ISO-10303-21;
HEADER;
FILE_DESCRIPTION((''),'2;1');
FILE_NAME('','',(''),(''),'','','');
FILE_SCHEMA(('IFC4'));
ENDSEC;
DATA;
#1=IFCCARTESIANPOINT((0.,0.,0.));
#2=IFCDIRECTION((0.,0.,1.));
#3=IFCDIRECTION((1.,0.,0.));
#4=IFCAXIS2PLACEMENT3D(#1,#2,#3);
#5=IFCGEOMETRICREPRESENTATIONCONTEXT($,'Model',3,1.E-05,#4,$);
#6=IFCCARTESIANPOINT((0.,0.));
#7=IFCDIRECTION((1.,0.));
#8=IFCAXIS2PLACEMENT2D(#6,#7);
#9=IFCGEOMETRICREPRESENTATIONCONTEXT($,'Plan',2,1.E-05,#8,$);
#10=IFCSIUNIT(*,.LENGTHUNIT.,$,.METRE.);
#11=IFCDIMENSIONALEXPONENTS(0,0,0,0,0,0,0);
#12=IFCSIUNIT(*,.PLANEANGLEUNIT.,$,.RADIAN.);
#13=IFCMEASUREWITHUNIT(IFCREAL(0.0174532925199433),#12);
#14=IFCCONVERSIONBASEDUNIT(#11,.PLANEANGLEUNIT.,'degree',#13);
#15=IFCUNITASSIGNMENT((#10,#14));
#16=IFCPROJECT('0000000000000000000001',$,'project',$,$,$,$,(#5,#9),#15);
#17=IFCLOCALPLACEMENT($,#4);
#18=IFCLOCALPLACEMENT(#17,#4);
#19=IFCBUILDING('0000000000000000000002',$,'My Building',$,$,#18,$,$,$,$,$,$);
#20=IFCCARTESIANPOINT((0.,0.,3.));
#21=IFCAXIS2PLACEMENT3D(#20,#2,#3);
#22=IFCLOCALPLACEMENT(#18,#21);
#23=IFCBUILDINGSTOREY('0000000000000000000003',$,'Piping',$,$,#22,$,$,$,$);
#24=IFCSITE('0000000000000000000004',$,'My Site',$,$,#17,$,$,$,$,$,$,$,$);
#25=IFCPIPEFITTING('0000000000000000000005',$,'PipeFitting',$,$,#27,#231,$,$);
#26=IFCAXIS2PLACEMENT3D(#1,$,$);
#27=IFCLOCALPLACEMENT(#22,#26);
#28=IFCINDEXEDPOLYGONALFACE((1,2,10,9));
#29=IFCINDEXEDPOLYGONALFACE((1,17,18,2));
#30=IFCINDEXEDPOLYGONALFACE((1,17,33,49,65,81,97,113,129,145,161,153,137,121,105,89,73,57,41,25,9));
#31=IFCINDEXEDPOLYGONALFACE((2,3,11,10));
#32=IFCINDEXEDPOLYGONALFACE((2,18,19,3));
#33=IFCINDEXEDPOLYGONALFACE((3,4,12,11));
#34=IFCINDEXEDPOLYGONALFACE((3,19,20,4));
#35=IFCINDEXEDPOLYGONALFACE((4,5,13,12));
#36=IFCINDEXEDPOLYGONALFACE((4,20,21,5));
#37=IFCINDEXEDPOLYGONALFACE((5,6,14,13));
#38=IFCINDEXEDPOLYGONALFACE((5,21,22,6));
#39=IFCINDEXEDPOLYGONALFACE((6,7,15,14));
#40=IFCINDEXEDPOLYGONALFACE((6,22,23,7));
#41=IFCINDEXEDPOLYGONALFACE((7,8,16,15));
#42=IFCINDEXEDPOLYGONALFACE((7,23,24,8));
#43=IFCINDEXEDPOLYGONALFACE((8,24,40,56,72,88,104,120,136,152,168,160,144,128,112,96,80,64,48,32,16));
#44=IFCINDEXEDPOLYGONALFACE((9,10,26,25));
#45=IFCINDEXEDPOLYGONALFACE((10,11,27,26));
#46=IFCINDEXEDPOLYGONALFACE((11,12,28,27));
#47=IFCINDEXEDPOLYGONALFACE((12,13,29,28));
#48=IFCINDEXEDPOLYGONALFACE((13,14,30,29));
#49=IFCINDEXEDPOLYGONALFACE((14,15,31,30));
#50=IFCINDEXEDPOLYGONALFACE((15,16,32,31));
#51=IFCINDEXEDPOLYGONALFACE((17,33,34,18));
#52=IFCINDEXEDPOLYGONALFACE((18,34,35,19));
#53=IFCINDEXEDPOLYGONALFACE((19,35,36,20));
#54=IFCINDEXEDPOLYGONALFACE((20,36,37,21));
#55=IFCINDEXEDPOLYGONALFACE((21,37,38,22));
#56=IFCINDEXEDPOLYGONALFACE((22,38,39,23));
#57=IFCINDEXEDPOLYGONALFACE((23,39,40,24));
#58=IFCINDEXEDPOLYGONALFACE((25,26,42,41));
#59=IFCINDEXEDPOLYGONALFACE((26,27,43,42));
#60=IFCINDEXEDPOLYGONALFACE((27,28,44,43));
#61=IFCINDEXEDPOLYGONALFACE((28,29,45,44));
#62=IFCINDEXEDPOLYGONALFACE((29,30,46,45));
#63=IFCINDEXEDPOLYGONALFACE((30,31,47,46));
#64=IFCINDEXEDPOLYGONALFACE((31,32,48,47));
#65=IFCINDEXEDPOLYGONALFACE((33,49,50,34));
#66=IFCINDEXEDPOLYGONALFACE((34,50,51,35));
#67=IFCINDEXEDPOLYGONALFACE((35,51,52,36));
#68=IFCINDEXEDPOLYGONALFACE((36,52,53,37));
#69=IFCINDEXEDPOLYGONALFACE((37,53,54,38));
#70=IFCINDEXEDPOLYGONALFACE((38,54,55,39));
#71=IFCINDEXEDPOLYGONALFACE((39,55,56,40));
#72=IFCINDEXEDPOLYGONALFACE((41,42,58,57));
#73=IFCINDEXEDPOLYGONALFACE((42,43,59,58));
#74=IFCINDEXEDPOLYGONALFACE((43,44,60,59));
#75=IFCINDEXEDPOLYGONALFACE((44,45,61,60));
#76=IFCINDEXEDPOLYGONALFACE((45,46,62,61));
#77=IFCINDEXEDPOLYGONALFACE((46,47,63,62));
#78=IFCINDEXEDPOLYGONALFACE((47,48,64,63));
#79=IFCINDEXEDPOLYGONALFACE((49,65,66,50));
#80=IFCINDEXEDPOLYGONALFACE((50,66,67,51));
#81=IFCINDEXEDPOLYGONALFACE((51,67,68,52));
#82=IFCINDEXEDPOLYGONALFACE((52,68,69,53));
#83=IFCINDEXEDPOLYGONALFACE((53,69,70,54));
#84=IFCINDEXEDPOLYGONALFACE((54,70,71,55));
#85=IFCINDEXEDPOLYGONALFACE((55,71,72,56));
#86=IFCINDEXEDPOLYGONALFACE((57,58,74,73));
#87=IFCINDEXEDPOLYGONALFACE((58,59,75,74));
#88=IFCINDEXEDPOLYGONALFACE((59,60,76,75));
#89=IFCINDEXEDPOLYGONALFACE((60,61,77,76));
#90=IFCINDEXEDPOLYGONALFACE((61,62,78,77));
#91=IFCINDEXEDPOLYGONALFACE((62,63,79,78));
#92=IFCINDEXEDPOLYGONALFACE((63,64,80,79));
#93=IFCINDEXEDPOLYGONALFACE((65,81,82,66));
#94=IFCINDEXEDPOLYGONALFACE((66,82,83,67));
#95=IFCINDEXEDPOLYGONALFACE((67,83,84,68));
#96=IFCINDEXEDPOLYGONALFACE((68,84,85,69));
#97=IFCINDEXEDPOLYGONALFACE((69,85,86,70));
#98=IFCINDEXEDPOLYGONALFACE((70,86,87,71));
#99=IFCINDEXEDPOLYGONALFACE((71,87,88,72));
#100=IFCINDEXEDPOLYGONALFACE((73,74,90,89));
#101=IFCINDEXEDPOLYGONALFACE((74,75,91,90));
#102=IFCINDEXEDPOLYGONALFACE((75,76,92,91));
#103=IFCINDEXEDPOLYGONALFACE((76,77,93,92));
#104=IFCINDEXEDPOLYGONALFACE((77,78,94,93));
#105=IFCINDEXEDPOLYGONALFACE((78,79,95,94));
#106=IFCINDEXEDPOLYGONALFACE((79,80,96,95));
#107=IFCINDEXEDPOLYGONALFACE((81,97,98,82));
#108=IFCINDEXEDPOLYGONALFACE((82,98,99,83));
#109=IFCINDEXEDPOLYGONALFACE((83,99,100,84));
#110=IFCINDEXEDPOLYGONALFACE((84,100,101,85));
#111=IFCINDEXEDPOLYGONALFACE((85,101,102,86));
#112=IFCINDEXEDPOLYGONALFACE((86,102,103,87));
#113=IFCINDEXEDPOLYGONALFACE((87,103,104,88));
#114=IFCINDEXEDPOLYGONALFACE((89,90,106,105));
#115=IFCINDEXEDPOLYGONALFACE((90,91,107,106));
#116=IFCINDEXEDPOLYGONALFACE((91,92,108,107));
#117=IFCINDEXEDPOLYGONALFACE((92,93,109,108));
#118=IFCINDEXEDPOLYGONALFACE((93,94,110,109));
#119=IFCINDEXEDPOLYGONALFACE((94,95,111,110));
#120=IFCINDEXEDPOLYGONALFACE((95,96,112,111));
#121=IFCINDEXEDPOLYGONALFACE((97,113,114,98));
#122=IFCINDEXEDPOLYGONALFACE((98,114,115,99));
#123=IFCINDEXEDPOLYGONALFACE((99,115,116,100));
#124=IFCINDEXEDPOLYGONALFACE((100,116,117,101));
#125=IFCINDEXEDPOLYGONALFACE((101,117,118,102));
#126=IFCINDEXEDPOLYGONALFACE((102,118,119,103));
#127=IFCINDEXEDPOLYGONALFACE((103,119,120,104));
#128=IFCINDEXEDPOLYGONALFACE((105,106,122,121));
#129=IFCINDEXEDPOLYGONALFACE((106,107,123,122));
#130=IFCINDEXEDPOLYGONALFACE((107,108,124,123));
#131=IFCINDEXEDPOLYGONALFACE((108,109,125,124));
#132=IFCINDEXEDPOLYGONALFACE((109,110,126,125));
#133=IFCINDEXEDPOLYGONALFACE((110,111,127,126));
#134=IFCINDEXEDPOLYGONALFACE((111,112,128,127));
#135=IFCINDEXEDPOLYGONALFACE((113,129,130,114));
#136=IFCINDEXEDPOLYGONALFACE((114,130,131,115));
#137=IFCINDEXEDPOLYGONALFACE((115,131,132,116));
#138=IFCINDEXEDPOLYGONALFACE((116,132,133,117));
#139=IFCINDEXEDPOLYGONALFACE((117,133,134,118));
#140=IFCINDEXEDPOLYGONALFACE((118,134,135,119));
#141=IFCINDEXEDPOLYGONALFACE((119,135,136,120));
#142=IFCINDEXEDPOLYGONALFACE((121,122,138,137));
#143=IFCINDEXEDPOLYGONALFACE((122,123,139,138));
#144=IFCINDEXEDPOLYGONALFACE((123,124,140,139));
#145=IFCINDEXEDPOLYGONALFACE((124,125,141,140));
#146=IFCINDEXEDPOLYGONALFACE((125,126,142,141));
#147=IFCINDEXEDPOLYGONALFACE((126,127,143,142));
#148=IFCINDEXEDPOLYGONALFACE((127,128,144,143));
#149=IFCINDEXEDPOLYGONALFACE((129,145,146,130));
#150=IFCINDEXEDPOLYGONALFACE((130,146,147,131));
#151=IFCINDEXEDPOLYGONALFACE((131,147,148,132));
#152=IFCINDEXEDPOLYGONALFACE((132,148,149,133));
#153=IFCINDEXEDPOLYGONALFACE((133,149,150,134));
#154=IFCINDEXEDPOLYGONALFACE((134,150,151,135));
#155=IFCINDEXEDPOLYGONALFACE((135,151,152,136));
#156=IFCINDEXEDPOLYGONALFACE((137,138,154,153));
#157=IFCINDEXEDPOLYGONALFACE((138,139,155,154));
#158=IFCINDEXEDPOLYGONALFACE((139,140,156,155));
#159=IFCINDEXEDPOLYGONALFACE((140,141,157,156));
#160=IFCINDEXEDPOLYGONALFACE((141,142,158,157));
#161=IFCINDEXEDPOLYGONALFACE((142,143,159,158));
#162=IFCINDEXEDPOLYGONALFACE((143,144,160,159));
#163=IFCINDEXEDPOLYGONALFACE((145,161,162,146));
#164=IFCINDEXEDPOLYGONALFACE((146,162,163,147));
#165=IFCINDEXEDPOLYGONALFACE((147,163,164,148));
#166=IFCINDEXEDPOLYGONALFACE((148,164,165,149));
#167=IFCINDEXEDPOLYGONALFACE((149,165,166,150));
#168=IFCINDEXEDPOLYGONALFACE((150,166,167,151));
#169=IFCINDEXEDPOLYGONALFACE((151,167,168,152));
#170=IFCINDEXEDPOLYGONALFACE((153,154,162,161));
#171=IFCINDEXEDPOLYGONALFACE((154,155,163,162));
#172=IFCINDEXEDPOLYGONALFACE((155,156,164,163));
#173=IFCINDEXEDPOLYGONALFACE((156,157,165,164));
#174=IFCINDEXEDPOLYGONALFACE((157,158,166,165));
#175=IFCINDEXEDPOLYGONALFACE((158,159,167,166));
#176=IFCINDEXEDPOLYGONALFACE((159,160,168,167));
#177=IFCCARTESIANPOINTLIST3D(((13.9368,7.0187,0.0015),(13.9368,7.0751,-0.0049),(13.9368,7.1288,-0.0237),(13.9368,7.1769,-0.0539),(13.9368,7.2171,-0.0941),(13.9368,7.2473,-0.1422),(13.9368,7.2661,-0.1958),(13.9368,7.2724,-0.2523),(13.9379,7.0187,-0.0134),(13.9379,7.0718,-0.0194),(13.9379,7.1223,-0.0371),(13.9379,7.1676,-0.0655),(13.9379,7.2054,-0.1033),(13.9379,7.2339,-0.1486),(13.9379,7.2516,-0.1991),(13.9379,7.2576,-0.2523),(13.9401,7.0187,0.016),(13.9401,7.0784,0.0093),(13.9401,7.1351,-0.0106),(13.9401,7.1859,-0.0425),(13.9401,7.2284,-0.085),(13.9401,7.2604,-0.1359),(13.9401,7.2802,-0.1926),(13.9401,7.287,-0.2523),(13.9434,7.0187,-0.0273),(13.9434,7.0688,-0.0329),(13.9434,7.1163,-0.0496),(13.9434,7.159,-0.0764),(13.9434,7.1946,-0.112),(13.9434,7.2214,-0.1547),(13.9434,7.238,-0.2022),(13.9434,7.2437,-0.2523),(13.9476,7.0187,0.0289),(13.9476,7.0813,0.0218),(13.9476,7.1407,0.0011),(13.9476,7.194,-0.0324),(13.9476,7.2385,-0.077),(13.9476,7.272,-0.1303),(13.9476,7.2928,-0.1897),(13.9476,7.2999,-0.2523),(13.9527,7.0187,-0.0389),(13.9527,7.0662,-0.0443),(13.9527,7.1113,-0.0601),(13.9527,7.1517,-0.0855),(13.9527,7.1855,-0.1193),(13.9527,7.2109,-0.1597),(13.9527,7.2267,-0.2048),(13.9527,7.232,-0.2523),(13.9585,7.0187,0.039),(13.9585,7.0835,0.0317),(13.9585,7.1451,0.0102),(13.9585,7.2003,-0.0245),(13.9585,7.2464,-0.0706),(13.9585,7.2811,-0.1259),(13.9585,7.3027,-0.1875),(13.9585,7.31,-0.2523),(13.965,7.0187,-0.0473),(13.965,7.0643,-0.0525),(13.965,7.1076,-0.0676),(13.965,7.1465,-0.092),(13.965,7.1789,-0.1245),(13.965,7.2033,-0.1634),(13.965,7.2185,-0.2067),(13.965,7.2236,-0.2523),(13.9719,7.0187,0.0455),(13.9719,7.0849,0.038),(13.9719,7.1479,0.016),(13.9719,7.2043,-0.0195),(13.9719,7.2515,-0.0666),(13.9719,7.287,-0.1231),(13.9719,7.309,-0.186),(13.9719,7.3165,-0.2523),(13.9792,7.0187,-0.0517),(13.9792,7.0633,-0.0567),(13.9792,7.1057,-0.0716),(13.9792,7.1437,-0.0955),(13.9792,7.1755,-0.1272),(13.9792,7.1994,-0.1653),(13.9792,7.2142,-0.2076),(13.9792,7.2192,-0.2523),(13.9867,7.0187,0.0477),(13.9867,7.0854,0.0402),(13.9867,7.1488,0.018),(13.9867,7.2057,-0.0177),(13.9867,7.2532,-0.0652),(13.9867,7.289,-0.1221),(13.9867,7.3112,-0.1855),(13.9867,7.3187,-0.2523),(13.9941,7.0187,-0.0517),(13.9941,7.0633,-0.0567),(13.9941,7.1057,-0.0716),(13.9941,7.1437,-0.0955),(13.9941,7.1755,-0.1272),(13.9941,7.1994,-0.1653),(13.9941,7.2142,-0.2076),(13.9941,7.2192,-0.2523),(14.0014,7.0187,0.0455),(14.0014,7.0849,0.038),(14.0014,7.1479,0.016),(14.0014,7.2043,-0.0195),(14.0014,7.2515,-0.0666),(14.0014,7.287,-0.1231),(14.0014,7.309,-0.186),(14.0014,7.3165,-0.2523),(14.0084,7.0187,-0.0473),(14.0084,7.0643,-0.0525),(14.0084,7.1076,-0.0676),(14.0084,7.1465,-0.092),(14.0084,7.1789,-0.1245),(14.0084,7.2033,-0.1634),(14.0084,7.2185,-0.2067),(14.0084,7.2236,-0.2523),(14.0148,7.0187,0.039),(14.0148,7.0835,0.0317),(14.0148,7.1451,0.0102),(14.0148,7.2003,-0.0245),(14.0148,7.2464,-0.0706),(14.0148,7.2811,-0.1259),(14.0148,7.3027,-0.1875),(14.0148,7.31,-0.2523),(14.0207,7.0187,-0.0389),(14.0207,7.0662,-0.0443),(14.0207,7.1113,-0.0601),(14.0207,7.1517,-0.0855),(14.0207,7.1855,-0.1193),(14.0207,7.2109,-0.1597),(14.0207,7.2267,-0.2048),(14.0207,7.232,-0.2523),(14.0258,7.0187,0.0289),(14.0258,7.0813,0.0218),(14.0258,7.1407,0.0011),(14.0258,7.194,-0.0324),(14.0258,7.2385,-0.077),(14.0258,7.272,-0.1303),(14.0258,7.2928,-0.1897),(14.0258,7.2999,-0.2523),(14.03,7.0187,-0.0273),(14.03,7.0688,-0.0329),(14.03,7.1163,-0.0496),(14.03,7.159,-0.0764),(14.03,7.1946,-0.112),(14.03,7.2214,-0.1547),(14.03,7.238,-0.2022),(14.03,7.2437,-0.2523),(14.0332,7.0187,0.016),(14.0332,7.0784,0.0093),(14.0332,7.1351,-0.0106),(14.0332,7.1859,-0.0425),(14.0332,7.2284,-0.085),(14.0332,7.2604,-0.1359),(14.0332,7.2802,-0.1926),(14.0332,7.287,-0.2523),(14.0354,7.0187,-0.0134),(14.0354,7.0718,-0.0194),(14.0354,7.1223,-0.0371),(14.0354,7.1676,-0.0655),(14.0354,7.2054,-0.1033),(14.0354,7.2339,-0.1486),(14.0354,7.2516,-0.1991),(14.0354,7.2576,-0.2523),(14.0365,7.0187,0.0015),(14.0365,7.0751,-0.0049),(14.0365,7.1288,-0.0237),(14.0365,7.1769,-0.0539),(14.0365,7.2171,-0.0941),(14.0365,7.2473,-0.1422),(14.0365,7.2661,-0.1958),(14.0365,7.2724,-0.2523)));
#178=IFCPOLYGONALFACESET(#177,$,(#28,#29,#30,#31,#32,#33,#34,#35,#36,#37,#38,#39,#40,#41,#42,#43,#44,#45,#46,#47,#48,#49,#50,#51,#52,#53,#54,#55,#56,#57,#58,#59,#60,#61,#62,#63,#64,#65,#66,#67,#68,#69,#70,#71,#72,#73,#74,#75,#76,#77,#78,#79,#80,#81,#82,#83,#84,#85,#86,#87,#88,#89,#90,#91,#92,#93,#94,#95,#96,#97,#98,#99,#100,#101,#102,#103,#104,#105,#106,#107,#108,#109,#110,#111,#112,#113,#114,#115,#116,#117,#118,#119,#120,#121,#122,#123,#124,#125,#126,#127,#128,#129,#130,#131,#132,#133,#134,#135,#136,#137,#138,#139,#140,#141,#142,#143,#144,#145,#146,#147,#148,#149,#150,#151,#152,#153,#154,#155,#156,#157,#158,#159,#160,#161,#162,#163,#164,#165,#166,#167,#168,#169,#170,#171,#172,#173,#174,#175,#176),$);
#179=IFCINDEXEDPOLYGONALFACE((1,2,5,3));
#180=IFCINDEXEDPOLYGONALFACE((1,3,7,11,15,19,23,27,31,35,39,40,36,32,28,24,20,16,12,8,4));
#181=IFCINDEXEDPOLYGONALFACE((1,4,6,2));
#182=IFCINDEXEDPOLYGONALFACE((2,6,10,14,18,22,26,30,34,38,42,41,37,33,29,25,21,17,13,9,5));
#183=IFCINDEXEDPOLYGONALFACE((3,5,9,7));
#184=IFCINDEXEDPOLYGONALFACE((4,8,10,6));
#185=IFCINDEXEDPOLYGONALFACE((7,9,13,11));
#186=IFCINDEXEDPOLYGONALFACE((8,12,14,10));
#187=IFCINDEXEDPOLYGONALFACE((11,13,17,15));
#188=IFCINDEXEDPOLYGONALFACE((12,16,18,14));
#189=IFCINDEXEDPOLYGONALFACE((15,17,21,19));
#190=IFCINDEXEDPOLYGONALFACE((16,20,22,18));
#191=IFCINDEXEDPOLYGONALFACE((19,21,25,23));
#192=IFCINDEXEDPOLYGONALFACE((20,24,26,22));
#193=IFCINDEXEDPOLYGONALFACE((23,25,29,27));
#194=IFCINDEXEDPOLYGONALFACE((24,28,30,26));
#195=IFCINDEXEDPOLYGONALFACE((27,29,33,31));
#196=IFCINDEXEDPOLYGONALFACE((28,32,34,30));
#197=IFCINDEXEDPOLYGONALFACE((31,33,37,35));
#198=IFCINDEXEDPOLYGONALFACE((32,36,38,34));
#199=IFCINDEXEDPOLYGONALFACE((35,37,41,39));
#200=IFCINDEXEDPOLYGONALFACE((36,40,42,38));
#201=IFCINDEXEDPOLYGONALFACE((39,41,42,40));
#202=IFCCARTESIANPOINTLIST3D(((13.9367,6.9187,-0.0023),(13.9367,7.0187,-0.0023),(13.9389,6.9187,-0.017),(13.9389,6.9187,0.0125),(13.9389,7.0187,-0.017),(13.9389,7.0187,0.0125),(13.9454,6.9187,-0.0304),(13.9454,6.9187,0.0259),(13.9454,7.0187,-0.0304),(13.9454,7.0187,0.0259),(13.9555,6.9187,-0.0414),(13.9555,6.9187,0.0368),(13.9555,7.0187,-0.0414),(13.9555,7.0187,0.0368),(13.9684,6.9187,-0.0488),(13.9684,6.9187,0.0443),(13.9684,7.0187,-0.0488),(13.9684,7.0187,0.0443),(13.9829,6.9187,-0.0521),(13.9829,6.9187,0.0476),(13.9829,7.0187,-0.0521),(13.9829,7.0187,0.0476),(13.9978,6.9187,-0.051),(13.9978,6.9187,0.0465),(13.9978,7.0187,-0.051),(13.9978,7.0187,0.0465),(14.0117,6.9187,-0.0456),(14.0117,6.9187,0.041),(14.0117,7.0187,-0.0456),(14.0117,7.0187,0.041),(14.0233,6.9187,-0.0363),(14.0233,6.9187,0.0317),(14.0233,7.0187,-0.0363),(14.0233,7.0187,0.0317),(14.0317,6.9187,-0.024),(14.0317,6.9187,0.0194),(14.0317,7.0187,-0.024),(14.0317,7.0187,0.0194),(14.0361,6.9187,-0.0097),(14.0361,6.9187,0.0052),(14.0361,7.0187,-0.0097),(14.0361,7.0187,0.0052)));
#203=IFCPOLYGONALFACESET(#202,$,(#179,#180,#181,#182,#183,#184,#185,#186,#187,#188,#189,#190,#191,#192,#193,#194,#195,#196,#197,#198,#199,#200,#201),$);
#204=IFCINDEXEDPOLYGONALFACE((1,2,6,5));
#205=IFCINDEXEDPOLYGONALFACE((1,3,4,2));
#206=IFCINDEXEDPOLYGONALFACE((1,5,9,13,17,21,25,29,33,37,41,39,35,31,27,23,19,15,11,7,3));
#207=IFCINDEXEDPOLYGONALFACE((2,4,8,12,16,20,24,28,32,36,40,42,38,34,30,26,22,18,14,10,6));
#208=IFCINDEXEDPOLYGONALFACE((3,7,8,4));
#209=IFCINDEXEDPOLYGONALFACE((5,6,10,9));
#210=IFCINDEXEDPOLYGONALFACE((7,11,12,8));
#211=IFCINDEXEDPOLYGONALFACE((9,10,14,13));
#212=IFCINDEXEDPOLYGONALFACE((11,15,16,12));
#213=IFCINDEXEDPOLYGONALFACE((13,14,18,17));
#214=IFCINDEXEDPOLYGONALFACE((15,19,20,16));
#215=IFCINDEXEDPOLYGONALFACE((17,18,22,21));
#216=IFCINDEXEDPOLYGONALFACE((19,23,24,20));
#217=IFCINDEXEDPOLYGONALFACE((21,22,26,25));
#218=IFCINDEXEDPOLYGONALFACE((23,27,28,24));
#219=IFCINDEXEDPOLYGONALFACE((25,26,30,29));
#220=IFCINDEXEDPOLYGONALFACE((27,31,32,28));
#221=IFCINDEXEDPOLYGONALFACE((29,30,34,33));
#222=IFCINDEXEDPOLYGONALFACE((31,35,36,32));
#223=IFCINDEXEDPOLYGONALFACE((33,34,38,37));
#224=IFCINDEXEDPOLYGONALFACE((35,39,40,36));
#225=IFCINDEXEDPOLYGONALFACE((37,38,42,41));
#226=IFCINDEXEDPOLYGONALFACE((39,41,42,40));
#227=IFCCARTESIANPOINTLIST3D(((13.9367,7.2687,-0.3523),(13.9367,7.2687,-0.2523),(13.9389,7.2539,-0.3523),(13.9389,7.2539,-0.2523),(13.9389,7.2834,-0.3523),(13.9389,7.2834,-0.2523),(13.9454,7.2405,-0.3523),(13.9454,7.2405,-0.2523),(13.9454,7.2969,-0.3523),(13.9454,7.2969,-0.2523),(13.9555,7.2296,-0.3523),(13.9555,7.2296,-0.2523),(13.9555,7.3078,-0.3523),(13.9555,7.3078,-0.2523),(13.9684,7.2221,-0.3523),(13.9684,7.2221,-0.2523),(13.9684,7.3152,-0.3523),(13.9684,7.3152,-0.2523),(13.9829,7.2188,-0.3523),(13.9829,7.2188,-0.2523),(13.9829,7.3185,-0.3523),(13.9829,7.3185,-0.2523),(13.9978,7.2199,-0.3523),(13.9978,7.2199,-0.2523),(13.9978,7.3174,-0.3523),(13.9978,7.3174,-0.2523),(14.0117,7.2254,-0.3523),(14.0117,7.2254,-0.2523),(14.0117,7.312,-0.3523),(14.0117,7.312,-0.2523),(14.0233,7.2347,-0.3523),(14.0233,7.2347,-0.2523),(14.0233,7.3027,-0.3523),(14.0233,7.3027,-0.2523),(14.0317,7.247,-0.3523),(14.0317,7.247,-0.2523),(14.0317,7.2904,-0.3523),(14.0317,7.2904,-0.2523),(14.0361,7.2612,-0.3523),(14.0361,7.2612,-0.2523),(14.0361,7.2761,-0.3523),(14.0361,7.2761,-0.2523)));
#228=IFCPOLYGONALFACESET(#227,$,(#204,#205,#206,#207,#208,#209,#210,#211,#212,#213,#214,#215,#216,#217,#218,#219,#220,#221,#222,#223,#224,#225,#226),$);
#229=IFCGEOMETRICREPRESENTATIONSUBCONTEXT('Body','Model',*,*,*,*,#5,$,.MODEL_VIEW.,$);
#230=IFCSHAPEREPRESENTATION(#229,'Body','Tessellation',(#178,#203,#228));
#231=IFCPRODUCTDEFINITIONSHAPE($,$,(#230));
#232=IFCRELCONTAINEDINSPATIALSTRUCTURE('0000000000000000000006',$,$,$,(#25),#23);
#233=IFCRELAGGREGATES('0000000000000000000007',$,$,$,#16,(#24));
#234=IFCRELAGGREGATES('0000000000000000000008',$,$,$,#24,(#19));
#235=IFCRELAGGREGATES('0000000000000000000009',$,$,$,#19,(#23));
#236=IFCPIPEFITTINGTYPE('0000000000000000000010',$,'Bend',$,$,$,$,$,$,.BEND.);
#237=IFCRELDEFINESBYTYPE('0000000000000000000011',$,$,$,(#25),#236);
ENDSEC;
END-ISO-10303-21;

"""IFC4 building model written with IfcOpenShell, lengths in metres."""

from ifc_helpers import new_model, entity, si_unit, converted_unit, frame, origin_with_axes, origin_2d_with_axis, place, context, subcontext, project, spatial, circle, extrude, source, transform, mapped, type_object, type_shapes, element, save


model = new_model("IFC4")

# Units and contexts
model_context = context("Model", 3, precision=1e-05, world=origin_with_axes())
plan_context = context("Plan", 2, precision=1e-05, world=origin_2d_with_axis())
body_context = subcontext(model_context, "Body", "Model", "MODEL_VIEW")
ifc_project = project(units=[si_unit("LENGTHUNIT", "METRE"), converted_unit("PLANEANGLEUNIT", "degree", entity("IfcReal", 0.0174532925199433), si_unit("PLANEANGLEUNIT", "RADIAN"), dimensions=[0, 0, 0, 0, 0, 0, 0])], contexts=[model_context, plan_context])

# Site, building, storey
site_placement = place(None, origin_with_axes())
site = spatial("IfcSite", under=ifc_project, at=site_placement, Name="My Site")
building_placement = place(site_placement, origin_with_axes())
building = spatial("IfcBuilding", under=site, at=building_placement, Name="My Building")
storey_placement = place(building_placement, frame((0.0, 0.0, 3.0), z_axis=(0.0, 0.0, 1.0), x_axis=(1.0, 0.0, 0.0)))
storey = spatial("IfcBuildingStorey", under=building, at=storey_placement, Name="Piping")

# Pipe fitting
pipe_fitting_type_1 = type_object("IfcPipeFittingType", Name="Bend", PredefinedType="BEND")
shared_shape = source(origin_with_axes(), body_context, "Body", "SolidModel", [
    entity("IfcSweptDiskSolid", entity("IfcIndexedPolyCurve", entity("IfcCartesianPointList3D", [[0.0, 0.0, -0.1], [0.0, 0.0732, -0.2768], [0.0, 0.25, -0.35]]), [entity("IfcArcIndex", [1, 2, 3])]), 0.05),
    extrude(circle(Radius=0.05), origin_with_axes(), (0.0, 0.0, -1.0), 0.1),
    extrude(circle(Radius=0.05), frame((0.0, 0.25, -0.35), z_axis=(0.0, 1.0, 0.0), x_axis=(1.0, 0.0, 0.0)), (0.0, 0.0, 1.0), 0.1),
])
type_shapes(pipe_fitting_type_1, [shared_shape])
for number, where, z_axis, x_axis, name in (
    (1, (13.9867, 6.9187, -0.0023), (0.0, -1.0, 0.0), (-1.0, 0.0, 0.0), "PipeFitting"),
):
    element("IfcPipeFitting", number, at=place(storey_placement, frame(where, z_axis=z_axis, x_axis=x_axis)), inside=storey, type_object=pipe_fitting_type_1, Name=name, context=body_context, shape_type="MappedRepresentation", body=[
        mapped(shared_shape, transform((0.0, 0.0, 0.0), x_axis=(1.0, 0.0, 0.0), y_axis=(0.0, 1.0, 0.0), z_axis=(0.0, 0.0, 1.0), scale=1.0)),
    ])

save(model, "model.ifc")
